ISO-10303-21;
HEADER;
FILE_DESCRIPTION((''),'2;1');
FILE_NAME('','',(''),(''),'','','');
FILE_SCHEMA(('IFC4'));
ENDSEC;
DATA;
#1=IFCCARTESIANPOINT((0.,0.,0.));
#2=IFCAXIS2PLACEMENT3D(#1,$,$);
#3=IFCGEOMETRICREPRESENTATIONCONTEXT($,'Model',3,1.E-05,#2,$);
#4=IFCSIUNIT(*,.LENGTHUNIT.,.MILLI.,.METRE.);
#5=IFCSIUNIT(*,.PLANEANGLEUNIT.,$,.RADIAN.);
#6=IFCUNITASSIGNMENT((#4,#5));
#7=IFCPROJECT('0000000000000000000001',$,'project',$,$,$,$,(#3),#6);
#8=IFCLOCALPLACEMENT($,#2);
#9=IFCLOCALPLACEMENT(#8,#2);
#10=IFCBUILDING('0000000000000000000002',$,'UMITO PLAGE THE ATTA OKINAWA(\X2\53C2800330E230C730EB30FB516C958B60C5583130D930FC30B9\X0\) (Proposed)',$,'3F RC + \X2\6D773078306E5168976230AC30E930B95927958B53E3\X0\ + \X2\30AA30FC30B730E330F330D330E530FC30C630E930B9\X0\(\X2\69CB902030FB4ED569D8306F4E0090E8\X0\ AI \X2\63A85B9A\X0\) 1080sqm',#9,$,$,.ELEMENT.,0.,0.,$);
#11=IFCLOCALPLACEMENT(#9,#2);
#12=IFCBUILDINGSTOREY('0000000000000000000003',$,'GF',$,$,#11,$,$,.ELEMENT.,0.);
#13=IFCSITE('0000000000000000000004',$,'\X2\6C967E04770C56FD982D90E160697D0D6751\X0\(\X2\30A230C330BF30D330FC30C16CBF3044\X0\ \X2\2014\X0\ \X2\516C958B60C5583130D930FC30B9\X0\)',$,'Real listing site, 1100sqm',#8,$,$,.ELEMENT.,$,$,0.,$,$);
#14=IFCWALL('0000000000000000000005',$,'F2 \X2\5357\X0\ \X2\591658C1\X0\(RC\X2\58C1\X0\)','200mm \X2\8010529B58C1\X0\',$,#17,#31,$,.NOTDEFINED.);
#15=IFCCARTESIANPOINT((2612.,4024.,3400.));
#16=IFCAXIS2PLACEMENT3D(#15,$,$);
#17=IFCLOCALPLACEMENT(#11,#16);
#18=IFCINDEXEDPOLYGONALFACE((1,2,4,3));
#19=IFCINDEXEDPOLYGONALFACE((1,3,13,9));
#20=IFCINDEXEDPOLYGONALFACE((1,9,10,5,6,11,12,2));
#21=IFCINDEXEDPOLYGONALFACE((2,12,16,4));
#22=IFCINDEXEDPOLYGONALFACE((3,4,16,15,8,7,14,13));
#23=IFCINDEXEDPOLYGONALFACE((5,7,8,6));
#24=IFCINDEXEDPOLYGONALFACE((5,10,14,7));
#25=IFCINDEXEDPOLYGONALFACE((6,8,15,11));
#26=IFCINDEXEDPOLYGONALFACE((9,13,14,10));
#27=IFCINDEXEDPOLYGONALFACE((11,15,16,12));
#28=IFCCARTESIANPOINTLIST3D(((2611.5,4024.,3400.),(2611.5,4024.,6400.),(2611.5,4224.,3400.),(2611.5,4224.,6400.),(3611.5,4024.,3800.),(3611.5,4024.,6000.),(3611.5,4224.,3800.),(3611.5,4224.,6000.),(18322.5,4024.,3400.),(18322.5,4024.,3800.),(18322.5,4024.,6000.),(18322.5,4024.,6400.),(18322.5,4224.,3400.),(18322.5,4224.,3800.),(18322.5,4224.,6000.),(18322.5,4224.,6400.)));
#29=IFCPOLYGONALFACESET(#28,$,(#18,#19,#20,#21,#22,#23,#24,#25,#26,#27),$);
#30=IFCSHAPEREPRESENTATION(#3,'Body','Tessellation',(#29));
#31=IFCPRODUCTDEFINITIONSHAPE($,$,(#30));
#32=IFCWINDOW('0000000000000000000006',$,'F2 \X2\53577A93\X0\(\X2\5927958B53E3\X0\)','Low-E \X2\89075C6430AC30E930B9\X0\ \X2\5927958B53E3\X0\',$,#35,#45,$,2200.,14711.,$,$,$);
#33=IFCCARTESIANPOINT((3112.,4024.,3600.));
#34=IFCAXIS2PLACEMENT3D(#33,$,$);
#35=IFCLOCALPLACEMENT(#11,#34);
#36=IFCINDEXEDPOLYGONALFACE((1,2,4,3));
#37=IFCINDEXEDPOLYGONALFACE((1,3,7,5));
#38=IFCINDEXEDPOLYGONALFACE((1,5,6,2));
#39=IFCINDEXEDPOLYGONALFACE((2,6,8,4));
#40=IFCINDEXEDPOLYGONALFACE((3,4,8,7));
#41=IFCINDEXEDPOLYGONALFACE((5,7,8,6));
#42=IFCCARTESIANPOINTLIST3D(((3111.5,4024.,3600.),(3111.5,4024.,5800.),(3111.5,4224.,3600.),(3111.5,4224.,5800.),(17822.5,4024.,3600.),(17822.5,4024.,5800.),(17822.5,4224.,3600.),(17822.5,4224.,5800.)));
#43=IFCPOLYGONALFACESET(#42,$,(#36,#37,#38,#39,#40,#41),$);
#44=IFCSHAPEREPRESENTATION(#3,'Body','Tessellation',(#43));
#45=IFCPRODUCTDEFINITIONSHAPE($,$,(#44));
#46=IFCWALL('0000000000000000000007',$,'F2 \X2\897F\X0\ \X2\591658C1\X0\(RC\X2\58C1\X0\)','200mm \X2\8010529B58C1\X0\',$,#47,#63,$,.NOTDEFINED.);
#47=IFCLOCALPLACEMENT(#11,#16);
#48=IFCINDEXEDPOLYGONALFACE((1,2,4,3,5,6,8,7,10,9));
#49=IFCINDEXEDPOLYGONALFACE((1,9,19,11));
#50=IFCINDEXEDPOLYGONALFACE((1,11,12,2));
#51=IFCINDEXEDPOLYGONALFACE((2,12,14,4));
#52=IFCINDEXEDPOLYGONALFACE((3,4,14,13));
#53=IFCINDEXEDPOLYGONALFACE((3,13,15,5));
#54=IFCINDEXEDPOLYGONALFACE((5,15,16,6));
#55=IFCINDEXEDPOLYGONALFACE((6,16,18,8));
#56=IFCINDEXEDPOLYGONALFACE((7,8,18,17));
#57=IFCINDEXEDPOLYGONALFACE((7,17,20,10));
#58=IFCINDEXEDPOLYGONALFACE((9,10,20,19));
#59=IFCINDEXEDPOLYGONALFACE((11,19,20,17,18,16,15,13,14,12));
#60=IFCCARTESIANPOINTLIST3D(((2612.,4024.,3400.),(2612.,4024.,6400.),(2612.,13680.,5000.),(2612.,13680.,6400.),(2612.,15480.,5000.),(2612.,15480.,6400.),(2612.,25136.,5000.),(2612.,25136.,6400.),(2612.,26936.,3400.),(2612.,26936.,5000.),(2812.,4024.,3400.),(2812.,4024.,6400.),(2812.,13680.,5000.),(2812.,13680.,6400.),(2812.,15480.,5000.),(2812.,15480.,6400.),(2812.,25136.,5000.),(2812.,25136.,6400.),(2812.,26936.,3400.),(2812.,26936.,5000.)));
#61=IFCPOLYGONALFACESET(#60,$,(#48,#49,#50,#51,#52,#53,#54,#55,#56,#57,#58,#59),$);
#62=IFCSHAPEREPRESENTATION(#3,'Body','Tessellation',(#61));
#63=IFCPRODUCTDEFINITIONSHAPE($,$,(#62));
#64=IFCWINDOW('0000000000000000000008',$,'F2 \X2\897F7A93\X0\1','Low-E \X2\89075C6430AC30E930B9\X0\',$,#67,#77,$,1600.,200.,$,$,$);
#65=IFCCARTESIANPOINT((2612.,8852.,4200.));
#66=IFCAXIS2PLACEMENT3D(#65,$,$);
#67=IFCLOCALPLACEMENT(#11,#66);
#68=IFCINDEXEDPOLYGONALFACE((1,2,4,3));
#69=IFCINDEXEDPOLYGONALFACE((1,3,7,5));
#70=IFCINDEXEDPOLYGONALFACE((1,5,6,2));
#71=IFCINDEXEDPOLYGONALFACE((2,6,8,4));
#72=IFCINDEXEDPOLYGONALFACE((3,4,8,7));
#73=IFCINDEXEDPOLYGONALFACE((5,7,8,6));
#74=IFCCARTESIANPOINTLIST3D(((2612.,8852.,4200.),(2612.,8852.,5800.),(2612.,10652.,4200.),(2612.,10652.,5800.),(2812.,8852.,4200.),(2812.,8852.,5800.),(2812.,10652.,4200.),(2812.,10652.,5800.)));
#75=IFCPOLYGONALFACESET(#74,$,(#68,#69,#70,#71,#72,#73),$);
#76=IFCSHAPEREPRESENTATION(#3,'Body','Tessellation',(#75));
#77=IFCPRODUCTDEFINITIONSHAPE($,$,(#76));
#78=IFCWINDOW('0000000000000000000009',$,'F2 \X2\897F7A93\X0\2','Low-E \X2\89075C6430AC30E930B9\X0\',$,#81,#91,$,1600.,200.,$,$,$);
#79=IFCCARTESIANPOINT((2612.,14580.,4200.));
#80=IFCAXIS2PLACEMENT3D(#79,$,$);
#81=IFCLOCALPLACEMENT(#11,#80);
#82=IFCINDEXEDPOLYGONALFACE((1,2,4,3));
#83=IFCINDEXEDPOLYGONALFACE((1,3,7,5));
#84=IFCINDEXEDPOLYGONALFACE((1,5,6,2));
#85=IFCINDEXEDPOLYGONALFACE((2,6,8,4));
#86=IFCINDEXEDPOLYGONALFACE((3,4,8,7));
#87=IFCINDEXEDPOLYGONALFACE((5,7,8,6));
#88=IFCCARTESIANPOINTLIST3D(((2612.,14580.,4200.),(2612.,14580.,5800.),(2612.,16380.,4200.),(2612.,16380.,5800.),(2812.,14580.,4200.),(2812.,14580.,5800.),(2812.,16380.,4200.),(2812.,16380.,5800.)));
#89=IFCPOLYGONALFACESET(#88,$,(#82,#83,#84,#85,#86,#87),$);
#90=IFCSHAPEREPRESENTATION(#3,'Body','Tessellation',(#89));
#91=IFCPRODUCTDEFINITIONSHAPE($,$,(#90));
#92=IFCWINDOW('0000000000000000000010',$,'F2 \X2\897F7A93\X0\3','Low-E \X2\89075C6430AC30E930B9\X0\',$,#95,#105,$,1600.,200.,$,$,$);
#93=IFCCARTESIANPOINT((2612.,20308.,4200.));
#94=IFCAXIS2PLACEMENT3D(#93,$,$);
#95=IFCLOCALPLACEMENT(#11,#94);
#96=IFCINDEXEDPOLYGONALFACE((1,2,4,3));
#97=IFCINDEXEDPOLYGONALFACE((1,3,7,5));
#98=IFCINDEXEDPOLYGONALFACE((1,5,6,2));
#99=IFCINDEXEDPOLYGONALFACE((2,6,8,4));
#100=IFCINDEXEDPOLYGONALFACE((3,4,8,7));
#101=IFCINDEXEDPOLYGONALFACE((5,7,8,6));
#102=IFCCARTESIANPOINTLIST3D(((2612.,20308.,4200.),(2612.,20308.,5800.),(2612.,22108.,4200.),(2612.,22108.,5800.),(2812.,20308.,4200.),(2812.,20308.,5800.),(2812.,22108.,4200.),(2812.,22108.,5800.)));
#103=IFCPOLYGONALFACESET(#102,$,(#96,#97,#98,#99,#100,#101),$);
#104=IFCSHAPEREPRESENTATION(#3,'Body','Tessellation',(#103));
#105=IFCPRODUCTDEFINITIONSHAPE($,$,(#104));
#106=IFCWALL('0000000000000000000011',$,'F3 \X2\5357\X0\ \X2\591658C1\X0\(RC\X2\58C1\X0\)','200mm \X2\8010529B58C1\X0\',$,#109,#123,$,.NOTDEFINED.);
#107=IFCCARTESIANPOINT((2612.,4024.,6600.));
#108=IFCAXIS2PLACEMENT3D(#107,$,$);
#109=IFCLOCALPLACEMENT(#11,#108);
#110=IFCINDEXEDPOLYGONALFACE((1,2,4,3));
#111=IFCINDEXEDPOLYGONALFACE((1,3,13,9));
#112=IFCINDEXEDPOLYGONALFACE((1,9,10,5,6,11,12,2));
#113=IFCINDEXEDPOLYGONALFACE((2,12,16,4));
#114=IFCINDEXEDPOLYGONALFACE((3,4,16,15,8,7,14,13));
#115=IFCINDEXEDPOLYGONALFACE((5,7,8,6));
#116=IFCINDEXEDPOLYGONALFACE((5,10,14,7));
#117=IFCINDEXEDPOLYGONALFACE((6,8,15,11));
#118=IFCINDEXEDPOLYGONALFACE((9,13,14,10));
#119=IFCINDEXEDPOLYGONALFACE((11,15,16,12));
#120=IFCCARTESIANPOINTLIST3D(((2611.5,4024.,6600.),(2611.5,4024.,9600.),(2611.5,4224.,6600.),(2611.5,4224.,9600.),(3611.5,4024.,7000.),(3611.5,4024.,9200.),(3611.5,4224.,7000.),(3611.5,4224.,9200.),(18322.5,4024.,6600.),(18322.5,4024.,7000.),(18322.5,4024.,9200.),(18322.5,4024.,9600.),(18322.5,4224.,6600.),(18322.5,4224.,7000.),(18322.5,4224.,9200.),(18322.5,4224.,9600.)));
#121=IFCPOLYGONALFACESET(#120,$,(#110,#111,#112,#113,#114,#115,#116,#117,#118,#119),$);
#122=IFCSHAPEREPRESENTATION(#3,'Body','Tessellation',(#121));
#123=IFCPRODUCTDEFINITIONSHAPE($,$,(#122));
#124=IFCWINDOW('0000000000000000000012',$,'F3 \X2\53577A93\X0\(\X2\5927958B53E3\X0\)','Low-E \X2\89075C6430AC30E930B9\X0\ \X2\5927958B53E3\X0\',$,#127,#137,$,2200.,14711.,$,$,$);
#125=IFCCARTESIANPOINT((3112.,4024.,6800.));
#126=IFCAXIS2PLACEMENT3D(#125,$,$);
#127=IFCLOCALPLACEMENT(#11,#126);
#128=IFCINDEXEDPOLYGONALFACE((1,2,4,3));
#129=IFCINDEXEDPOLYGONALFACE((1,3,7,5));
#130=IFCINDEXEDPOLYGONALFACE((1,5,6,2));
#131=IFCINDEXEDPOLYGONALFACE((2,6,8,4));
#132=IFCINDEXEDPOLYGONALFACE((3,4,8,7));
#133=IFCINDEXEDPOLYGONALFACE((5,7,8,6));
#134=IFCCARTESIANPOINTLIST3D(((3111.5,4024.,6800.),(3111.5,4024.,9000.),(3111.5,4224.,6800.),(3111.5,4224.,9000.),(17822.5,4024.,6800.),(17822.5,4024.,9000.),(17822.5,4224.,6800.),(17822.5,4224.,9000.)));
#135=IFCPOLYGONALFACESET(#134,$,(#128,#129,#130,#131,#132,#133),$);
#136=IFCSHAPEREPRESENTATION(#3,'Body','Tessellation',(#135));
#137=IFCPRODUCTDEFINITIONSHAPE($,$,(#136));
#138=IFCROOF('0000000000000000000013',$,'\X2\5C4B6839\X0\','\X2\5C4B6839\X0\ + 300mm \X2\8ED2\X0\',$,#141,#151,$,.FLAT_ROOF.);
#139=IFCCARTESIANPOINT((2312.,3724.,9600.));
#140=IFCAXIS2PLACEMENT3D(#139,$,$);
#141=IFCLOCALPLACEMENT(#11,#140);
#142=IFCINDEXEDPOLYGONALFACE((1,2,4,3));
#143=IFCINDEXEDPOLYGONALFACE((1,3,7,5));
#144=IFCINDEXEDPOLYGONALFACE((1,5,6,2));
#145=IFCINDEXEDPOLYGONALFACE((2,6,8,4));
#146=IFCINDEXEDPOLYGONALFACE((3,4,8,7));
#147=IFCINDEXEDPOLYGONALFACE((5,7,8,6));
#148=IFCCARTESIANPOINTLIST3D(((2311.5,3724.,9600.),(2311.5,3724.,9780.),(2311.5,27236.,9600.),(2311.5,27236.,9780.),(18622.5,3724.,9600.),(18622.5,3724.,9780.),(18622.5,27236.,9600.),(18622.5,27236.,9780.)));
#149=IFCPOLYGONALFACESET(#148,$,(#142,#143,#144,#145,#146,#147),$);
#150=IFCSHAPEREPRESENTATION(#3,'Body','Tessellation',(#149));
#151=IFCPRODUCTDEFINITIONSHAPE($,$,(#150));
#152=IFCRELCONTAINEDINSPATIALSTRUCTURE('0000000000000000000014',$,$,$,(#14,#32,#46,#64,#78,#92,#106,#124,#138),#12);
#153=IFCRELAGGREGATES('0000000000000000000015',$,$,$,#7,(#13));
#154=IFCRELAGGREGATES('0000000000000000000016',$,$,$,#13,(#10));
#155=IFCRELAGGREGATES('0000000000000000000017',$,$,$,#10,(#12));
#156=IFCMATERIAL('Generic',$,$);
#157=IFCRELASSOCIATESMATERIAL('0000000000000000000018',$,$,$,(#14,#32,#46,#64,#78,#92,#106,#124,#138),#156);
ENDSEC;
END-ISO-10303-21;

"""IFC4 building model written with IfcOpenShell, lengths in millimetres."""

from ifc_helpers import new_model, si_unit, frame, frame_2d, origin, place, context, project, spatial, rectangle, extrude, material, element, fill, save


model = new_model("IFC4")

# Units and contexts
model_context = context("Model", 3, precision=1e-05, world=origin())
ifc_project = project(units=[si_unit("LENGTHUNIT", "METRE", prefix="MILLI"), si_unit("PLANEANGLEUNIT", "RADIAN")], contexts=[model_context])

# Site, building, storey
site_placement = place(None, origin())
site = spatial("IfcSite", under=ifc_project, at=site_placement, Name="沖縄県国頭郡恩納村(アッタビーチ沿い — 公開情報ベース)", ObjectType="Real listing site, 1100sqm", CompositionType="ELEMENT", RefElevation=0.0)
building_placement = place(site_placement, origin())
building = spatial("IfcBuilding", under=site, at=building_placement, Name="UMITO PLAGE THE ATTA OKINAWA(参考モデル・公開情報ベース) (Proposed)", ObjectType="3F RC + 海への全面ガラス大開口 + オーシャンビューテラス(構造・仕様は一部 AI 推定) 1080sqm", CompositionType="ELEMENT", ElevationOfRefHeight=0.0, ElevationOfTerrain=0.0)
storey_placement = place(building_placement, origin())
storey = spatial("IfcBuildingStorey", under=building, at=storey_placement, Name="GF", CompositionType="ELEMENT", Elevation=0.0)

# Shared definitions
ifc_material_1 = material(Name="Generic")

# Wall, opening, window
wall_1_placement = place(storey_placement, frame((2612.0, 4024.0, 3400.0)))
wall_1 = element("IfcWall", 1, at=wall_1_placement, inside=storey, material=ifc_material_1, Name="F2 南 外壁(RC壁)", Description="200mm 耐力壁", PredefinedType="NOTDEFINED", context=model_context, shape_type="SweptSolid", body=[
    extrude(rectangle(XDim=15711.0, YDim=200.0, at=frame_2d((7855.0, 100.0))), frame((2612.0, 4024.0, 3400.0)), (0.0, 0.0, 1.0), 3000.0),
])
opening_1_placement = place(storey_placement, frame((3112.0, 4024.0, 3600.0)))
opening_1 = element("IfcOpeningElement", 2, at=opening_1_placement, cuts=wall_1, PredefinedType="NOTDEFINED", context=model_context, shape_type="SweptSolid", body=[
    extrude(rectangle(XDim=14711.0, YDim=200.0, at=frame_2d((7355.0, 100.0))), frame((3112.0, 4024.0, 3600.0)), (0.0, 0.0, 1.0), 2200.0),
])
window_1_placement = place(storey_placement, frame((3112.0, 4024.0, 3600.0)))
window_1 = element("IfcWindow", 3, at=window_1_placement, inside=storey, material=ifc_material_1, Name="F2 南窓(大開口)", Description="Low-E 複層ガラス 大開口", OverallHeight=2200.0, OverallWidth=14711.0, context=model_context, shape_type="SweptSolid", body=[
    extrude(rectangle(XDim=14711.0, YDim=200.0, at=frame_2d((7355.0, 100.0))), frame((3112.0, 4024.0, 3600.0)), (0.0, 0.0, 1.0), 2200.0),
])
fill(opening_1, window_1)

# Wall, openings, windows
wall_2_placement = place(storey_placement, frame((2612.0, 4024.0, 3400.0)))
wall_2 = element("IfcWall", 4, at=wall_2_placement, inside=storey, material=ifc_material_1, Name="F2 西 外壁(RC壁)", Description="200mm 耐力壁", PredefinedType="NOTDEFINED", context=model_context, shape_type="SweptSolid", body=[
    extrude(rectangle(XDim=200.0, YDim=22912.0, at=frame_2d((100.0, 11456.0))), frame((2612.0, 4024.0, 3400.0)), (0.0, 0.0, 1.0), 3000.0),
])
opening_2_placement = place(storey_placement, frame((2612.0, 8852.0, 4200.0)))
opening_2 = element("IfcOpeningElement", 5, at=opening_2_placement, cuts=wall_2, PredefinedType="NOTDEFINED", context=model_context, shape_type="SweptSolid", body=[
    extrude(rectangle(XDim=200.0, YDim=1800.0, at=frame_2d((100.0, 900.0))), frame((2612.0, 8852.0, 4200.0)), (0.0, 0.0, 1.0), 1600.0),
])
opening_3_placement = place(storey_placement, frame((2612.0, 14580.0, 4200.0)))
opening_3 = element("IfcOpeningElement", 6, at=opening_3_placement, cuts=wall_2, PredefinedType="NOTDEFINED", context=model_context, shape_type="SweptSolid", body=[
    extrude(rectangle(XDim=200.0, YDim=1800.0, at=frame_2d((100.0, 900.0))), frame((2612.0, 14580.0, 4200.0)), (0.0, 0.0, 1.0), 1600.0),
])
opening_4_placement = place(storey_placement, frame((2612.0, 20308.0, 4200.0)))
opening_4 = element("IfcOpeningElement", 7, at=opening_4_placement, cuts=wall_2, PredefinedType="NOTDEFINED", context=model_context, shape_type="SweptSolid", body=[
    extrude(rectangle(XDim=200.0, YDim=1800.0, at=frame_2d((100.0, 900.0))), frame((2612.0, 20308.0, 4200.0)), (0.0, 0.0, 1.0), 1600.0),
])
window_2_placement = place(storey_placement, frame((2612.0, 8852.0, 4200.0)))
window_2 = element("IfcWindow", 8, at=window_2_placement, inside=storey, material=ifc_material_1, Name="F2 西窓1", Description="Low-E 複層ガラス", OverallHeight=1600.0, OverallWidth=200.0, context=model_context, shape_type="SweptSolid", body=[
    extrude(rectangle(XDim=200.0, YDim=1800.0, at=frame_2d((100.0, 900.0))), frame((2612.0, 8852.0, 4200.0)), (0.0, 0.0, 1.0), 1600.0),
])
fill(opening_2, window_2)
window_3_placement = place(storey_placement, frame((2612.0, 14580.0, 4200.0)))
window_3 = element("IfcWindow", 9, at=window_3_placement, inside=storey, material=ifc_material_1, Name="F2 西窓2", Description="Low-E 複層ガラス", OverallHeight=1600.0, OverallWidth=200.0, context=model_context, shape_type="SweptSolid", body=[
    extrude(rectangle(XDim=200.0, YDim=1800.0, at=frame_2d((100.0, 900.0))), frame((2612.0, 14580.0, 4200.0)), (0.0, 0.0, 1.0), 1600.0),
])
fill(opening_3, window_3)
window_4_placement = place(storey_placement, frame((2612.0, 20308.0, 4200.0)))
window_4 = element("IfcWindow", 10, at=window_4_placement, inside=storey, material=ifc_material_1, Name="F2 西窓3", Description="Low-E 複層ガラス", OverallHeight=1600.0, OverallWidth=200.0, context=model_context, shape_type="SweptSolid", body=[
    extrude(rectangle(XDim=200.0, YDim=1800.0, at=frame_2d((100.0, 900.0))), frame((2612.0, 20308.0, 4200.0)), (0.0, 0.0, 1.0), 1600.0),
])
fill(opening_4, window_4)

# Wall, opening, window
wall_3_placement = place(storey_placement, frame((2612.0, 4024.0, 6600.0)))
wall_3 = element("IfcWall", 11, at=wall_3_placement, inside=storey, material=ifc_material_1, Name="F3 南 外壁(RC壁)", Description="200mm 耐力壁", PredefinedType="NOTDEFINED", context=model_context, shape_type="SweptSolid", body=[
    extrude(rectangle(XDim=15711.0, YDim=200.0, at=frame_2d((7855.0, 100.0))), frame((2612.0, 4024.0, 6600.0)), (0.0, 0.0, 1.0), 3000.0),
])
opening_5_placement = place(storey_placement, frame((3112.0, 4024.0, 6800.0)))
opening_5 = element("IfcOpeningElement", 12, at=opening_5_placement, cuts=wall_3, PredefinedType="NOTDEFINED", context=model_context, shape_type="SweptSolid", body=[
    extrude(rectangle(XDim=14711.0, YDim=200.0, at=frame_2d((7355.0, 100.0))), frame((3112.0, 4024.0, 6800.0)), (0.0, 0.0, 1.0), 2200.0),
])
window_5_placement = place(storey_placement, frame((3112.0, 4024.0, 6800.0)))
window_5 = element("IfcWindow", 13, at=window_5_placement, inside=storey, material=ifc_material_1, Name="F3 南窓(大開口)", Description="Low-E 複層ガラス 大開口", OverallHeight=2200.0, OverallWidth=14711.0, context=model_context, shape_type="SweptSolid", body=[
    extrude(rectangle(XDim=14711.0, YDim=200.0, at=frame_2d((7355.0, 100.0))), frame((3112.0, 4024.0, 6800.0)), (0.0, 0.0, 1.0), 2200.0),
])
fill(opening_5, window_5)

# Roof
roof_placement = place(storey_placement, frame((2312.0, 3724.0, 9600.0)))
element("IfcRoof", 14, at=roof_placement, inside=storey, material=ifc_material_1, Name="屋根", Description="屋根 + 300mm 軒", PredefinedType="FLAT_ROOF", context=model_context, shape_type="SweptSolid", body=[
    extrude(rectangle(XDim=16311.0, YDim=23512.0, at=frame_2d((8155.0, 11756.0))), frame((2312.0, 3724.0, 9600.0)), (0.0, 0.0, 1.0), 180.0),
])

save(model, "model.ifc")
